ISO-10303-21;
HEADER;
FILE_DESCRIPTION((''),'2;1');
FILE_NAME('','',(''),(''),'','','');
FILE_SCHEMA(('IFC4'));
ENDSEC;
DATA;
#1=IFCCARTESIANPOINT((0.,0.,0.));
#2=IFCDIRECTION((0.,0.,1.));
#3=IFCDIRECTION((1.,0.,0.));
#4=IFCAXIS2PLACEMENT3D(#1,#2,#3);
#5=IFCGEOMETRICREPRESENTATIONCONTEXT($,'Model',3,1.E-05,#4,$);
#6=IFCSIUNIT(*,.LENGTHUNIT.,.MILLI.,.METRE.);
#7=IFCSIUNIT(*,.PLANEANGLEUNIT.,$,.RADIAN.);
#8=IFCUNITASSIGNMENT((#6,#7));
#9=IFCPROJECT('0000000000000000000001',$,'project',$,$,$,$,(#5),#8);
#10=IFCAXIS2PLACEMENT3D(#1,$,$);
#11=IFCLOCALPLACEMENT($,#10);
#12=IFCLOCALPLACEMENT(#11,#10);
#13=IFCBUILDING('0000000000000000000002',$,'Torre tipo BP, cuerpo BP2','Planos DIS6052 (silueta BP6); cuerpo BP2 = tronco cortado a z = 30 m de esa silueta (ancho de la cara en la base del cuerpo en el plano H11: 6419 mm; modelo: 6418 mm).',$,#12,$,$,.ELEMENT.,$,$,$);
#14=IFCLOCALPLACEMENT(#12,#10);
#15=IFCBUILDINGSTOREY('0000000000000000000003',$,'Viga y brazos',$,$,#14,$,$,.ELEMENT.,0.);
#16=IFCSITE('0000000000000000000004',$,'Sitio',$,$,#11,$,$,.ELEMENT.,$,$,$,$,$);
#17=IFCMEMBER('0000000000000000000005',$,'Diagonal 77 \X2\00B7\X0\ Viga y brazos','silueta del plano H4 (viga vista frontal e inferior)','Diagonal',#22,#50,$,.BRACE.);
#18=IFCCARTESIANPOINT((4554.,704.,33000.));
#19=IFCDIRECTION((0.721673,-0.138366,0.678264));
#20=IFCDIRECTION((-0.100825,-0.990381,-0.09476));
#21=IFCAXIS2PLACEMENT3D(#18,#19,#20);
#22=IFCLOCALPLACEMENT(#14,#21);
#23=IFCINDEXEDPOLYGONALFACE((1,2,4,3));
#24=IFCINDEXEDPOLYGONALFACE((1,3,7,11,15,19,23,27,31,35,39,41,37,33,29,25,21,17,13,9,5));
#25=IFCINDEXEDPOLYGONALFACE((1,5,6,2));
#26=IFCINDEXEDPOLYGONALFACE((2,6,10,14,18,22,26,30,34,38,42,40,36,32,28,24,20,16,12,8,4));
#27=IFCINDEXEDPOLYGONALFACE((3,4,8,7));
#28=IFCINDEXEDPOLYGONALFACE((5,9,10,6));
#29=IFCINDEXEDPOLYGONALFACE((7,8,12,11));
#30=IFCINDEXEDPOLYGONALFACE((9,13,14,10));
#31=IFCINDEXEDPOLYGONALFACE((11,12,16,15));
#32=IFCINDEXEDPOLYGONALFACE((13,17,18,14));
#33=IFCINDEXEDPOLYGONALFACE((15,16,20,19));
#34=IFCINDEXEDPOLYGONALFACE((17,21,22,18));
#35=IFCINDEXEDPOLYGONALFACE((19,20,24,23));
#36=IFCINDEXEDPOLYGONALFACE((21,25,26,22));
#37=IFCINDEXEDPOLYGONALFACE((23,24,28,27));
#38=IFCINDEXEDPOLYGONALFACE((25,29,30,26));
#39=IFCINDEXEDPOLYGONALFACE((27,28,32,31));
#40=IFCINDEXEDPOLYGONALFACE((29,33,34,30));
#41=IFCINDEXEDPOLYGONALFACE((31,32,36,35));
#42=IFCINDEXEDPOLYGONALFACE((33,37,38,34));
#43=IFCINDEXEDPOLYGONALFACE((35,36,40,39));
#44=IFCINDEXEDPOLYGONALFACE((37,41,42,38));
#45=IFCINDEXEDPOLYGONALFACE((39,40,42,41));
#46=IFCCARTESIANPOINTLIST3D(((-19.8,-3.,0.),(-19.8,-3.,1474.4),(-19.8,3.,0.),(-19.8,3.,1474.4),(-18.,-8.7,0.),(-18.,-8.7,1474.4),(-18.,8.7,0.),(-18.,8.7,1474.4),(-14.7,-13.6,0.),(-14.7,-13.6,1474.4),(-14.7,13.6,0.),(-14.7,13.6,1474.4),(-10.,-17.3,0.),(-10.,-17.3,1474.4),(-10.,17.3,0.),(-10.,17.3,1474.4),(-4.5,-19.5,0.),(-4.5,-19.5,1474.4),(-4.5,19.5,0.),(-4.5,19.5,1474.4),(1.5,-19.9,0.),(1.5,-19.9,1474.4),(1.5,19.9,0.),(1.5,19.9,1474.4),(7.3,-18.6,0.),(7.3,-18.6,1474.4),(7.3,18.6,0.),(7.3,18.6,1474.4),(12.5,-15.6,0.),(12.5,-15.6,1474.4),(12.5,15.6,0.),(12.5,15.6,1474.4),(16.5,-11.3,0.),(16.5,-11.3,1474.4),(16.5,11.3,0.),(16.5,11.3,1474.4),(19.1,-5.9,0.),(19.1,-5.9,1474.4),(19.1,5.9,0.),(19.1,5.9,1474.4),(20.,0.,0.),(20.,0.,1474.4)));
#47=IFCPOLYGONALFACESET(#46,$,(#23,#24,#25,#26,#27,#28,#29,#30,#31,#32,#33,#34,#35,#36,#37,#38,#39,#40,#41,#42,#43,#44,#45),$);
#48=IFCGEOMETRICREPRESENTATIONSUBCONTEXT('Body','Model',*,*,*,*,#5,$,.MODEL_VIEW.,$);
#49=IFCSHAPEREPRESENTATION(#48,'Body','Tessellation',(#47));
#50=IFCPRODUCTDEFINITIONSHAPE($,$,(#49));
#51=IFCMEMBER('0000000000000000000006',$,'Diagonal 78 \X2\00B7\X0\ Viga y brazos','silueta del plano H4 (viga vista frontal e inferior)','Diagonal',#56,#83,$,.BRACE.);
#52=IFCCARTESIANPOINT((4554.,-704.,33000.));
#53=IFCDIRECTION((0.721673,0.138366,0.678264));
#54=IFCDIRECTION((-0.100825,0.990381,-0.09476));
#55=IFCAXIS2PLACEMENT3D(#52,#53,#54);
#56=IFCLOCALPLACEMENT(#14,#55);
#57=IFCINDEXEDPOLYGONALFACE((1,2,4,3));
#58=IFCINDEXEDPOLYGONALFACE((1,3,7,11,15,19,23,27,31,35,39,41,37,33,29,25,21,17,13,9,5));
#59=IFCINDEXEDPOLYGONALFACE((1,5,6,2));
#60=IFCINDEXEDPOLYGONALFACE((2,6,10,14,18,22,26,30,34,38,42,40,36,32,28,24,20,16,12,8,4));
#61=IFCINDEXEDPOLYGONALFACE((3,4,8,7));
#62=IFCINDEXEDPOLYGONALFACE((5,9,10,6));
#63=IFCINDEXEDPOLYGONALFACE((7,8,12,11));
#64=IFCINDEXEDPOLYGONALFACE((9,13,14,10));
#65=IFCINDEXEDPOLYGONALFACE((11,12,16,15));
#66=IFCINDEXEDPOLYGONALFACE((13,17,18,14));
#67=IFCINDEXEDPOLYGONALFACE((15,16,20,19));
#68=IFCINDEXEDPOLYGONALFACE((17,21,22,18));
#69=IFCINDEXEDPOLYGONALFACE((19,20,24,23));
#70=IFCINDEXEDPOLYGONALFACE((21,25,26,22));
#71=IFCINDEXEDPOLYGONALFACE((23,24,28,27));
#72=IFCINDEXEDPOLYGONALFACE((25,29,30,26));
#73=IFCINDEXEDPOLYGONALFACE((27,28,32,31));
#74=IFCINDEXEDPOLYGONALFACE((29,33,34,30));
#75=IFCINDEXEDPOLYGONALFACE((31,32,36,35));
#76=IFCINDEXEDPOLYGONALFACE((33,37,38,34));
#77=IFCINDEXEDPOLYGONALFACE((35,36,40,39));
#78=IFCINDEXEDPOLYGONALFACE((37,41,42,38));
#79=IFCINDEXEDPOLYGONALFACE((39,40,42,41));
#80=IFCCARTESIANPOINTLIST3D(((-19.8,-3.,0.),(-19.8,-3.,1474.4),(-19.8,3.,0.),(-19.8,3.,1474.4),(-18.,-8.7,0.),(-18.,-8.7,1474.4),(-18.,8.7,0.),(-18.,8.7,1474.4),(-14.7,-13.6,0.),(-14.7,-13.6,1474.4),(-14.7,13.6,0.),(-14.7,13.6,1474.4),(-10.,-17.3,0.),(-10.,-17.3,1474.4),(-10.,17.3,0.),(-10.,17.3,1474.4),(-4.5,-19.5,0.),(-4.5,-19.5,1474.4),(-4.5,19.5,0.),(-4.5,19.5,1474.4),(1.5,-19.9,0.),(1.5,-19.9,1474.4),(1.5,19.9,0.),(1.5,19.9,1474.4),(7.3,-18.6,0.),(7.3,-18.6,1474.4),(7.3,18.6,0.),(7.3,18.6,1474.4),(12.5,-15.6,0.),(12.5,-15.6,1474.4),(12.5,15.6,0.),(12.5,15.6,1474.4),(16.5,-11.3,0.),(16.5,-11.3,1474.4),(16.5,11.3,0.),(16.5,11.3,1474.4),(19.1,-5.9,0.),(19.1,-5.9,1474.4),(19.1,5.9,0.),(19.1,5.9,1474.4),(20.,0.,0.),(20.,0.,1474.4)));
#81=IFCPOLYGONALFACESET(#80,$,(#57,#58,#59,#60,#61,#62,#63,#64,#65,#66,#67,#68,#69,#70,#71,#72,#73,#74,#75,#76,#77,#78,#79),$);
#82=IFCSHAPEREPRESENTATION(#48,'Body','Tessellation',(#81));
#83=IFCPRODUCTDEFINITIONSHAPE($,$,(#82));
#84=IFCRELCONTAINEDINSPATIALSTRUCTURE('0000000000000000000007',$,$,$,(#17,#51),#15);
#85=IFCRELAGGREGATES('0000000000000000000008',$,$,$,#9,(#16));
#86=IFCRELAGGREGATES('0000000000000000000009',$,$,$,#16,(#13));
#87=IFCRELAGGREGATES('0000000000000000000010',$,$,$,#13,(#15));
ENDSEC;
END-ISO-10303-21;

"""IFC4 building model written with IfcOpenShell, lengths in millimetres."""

from ifc_helpers import new_model, si_unit, frame, origin, origin_with_axes, place, context, subcontext, project, spatial, circle, extrude, element, save


model = new_model("IFC4")

# Units and contexts
model_context = context("Model", 3, precision=1e-05, world=origin_with_axes())
body_context = subcontext(model_context, "Body", "Model", "MODEL_VIEW")
ifc_project = project(units=[si_unit("LENGTHUNIT", "METRE", prefix="MILLI"), si_unit("PLANEANGLEUNIT", "RADIAN")], contexts=[model_context])

# Site, building, storey
site_placement = place(None, origin())
site = spatial("IfcSite", under=ifc_project, at=site_placement, Name="Sitio", CompositionType="ELEMENT")
building_placement = place(site_placement, origin())
building = spatial("IfcBuilding", under=site, at=building_placement, Name="Torre tipo BP, cuerpo BP2", Description="Planos DIS6052 (silueta BP6); cuerpo BP2 = tronco cortado a z = 30 m de esa silueta (ancho de la cara en la base del cuerpo en el plano H11: 6419 mm; modelo: 6418 mm).", CompositionType="ELEMENT")
storey_placement = place(building_placement, origin())
storey = spatial("IfcBuildingStorey", under=building, at=storey_placement, Name="Viga y brazos", CompositionType="ELEMENT", Elevation=0.0)

# Members
for number, where, z_axis, x_axis, name in (
    (1, (4554.0, 704.0, 33000.0), (0.721673, -0.138366, 0.678264), (-0.100825, -0.990381, -0.09476), "Diagonal 77 · Viga y brazos"),
    (2, (4554.0, -704.0, 33000.0), (0.721673, 0.138366, 0.678264), (-0.100825, 0.990381, -0.09476), "Diagonal 78 · Viga y brazos"),
):
    element("IfcMember", number, at=place(storey_placement, frame(where, z_axis=z_axis, x_axis=x_axis)), inside=storey, Name=name, Description="silueta del plano H4 (viga vista frontal e inferior)", ObjectType="Diagonal", PredefinedType="BRACE", context=body_context, shape_type="SweptSolid", body=[
        extrude(circle(Radius=20.0), None, (0.0, 0.0, 1.0), 1474.4),
    ])

save(model, "model.ifc")
